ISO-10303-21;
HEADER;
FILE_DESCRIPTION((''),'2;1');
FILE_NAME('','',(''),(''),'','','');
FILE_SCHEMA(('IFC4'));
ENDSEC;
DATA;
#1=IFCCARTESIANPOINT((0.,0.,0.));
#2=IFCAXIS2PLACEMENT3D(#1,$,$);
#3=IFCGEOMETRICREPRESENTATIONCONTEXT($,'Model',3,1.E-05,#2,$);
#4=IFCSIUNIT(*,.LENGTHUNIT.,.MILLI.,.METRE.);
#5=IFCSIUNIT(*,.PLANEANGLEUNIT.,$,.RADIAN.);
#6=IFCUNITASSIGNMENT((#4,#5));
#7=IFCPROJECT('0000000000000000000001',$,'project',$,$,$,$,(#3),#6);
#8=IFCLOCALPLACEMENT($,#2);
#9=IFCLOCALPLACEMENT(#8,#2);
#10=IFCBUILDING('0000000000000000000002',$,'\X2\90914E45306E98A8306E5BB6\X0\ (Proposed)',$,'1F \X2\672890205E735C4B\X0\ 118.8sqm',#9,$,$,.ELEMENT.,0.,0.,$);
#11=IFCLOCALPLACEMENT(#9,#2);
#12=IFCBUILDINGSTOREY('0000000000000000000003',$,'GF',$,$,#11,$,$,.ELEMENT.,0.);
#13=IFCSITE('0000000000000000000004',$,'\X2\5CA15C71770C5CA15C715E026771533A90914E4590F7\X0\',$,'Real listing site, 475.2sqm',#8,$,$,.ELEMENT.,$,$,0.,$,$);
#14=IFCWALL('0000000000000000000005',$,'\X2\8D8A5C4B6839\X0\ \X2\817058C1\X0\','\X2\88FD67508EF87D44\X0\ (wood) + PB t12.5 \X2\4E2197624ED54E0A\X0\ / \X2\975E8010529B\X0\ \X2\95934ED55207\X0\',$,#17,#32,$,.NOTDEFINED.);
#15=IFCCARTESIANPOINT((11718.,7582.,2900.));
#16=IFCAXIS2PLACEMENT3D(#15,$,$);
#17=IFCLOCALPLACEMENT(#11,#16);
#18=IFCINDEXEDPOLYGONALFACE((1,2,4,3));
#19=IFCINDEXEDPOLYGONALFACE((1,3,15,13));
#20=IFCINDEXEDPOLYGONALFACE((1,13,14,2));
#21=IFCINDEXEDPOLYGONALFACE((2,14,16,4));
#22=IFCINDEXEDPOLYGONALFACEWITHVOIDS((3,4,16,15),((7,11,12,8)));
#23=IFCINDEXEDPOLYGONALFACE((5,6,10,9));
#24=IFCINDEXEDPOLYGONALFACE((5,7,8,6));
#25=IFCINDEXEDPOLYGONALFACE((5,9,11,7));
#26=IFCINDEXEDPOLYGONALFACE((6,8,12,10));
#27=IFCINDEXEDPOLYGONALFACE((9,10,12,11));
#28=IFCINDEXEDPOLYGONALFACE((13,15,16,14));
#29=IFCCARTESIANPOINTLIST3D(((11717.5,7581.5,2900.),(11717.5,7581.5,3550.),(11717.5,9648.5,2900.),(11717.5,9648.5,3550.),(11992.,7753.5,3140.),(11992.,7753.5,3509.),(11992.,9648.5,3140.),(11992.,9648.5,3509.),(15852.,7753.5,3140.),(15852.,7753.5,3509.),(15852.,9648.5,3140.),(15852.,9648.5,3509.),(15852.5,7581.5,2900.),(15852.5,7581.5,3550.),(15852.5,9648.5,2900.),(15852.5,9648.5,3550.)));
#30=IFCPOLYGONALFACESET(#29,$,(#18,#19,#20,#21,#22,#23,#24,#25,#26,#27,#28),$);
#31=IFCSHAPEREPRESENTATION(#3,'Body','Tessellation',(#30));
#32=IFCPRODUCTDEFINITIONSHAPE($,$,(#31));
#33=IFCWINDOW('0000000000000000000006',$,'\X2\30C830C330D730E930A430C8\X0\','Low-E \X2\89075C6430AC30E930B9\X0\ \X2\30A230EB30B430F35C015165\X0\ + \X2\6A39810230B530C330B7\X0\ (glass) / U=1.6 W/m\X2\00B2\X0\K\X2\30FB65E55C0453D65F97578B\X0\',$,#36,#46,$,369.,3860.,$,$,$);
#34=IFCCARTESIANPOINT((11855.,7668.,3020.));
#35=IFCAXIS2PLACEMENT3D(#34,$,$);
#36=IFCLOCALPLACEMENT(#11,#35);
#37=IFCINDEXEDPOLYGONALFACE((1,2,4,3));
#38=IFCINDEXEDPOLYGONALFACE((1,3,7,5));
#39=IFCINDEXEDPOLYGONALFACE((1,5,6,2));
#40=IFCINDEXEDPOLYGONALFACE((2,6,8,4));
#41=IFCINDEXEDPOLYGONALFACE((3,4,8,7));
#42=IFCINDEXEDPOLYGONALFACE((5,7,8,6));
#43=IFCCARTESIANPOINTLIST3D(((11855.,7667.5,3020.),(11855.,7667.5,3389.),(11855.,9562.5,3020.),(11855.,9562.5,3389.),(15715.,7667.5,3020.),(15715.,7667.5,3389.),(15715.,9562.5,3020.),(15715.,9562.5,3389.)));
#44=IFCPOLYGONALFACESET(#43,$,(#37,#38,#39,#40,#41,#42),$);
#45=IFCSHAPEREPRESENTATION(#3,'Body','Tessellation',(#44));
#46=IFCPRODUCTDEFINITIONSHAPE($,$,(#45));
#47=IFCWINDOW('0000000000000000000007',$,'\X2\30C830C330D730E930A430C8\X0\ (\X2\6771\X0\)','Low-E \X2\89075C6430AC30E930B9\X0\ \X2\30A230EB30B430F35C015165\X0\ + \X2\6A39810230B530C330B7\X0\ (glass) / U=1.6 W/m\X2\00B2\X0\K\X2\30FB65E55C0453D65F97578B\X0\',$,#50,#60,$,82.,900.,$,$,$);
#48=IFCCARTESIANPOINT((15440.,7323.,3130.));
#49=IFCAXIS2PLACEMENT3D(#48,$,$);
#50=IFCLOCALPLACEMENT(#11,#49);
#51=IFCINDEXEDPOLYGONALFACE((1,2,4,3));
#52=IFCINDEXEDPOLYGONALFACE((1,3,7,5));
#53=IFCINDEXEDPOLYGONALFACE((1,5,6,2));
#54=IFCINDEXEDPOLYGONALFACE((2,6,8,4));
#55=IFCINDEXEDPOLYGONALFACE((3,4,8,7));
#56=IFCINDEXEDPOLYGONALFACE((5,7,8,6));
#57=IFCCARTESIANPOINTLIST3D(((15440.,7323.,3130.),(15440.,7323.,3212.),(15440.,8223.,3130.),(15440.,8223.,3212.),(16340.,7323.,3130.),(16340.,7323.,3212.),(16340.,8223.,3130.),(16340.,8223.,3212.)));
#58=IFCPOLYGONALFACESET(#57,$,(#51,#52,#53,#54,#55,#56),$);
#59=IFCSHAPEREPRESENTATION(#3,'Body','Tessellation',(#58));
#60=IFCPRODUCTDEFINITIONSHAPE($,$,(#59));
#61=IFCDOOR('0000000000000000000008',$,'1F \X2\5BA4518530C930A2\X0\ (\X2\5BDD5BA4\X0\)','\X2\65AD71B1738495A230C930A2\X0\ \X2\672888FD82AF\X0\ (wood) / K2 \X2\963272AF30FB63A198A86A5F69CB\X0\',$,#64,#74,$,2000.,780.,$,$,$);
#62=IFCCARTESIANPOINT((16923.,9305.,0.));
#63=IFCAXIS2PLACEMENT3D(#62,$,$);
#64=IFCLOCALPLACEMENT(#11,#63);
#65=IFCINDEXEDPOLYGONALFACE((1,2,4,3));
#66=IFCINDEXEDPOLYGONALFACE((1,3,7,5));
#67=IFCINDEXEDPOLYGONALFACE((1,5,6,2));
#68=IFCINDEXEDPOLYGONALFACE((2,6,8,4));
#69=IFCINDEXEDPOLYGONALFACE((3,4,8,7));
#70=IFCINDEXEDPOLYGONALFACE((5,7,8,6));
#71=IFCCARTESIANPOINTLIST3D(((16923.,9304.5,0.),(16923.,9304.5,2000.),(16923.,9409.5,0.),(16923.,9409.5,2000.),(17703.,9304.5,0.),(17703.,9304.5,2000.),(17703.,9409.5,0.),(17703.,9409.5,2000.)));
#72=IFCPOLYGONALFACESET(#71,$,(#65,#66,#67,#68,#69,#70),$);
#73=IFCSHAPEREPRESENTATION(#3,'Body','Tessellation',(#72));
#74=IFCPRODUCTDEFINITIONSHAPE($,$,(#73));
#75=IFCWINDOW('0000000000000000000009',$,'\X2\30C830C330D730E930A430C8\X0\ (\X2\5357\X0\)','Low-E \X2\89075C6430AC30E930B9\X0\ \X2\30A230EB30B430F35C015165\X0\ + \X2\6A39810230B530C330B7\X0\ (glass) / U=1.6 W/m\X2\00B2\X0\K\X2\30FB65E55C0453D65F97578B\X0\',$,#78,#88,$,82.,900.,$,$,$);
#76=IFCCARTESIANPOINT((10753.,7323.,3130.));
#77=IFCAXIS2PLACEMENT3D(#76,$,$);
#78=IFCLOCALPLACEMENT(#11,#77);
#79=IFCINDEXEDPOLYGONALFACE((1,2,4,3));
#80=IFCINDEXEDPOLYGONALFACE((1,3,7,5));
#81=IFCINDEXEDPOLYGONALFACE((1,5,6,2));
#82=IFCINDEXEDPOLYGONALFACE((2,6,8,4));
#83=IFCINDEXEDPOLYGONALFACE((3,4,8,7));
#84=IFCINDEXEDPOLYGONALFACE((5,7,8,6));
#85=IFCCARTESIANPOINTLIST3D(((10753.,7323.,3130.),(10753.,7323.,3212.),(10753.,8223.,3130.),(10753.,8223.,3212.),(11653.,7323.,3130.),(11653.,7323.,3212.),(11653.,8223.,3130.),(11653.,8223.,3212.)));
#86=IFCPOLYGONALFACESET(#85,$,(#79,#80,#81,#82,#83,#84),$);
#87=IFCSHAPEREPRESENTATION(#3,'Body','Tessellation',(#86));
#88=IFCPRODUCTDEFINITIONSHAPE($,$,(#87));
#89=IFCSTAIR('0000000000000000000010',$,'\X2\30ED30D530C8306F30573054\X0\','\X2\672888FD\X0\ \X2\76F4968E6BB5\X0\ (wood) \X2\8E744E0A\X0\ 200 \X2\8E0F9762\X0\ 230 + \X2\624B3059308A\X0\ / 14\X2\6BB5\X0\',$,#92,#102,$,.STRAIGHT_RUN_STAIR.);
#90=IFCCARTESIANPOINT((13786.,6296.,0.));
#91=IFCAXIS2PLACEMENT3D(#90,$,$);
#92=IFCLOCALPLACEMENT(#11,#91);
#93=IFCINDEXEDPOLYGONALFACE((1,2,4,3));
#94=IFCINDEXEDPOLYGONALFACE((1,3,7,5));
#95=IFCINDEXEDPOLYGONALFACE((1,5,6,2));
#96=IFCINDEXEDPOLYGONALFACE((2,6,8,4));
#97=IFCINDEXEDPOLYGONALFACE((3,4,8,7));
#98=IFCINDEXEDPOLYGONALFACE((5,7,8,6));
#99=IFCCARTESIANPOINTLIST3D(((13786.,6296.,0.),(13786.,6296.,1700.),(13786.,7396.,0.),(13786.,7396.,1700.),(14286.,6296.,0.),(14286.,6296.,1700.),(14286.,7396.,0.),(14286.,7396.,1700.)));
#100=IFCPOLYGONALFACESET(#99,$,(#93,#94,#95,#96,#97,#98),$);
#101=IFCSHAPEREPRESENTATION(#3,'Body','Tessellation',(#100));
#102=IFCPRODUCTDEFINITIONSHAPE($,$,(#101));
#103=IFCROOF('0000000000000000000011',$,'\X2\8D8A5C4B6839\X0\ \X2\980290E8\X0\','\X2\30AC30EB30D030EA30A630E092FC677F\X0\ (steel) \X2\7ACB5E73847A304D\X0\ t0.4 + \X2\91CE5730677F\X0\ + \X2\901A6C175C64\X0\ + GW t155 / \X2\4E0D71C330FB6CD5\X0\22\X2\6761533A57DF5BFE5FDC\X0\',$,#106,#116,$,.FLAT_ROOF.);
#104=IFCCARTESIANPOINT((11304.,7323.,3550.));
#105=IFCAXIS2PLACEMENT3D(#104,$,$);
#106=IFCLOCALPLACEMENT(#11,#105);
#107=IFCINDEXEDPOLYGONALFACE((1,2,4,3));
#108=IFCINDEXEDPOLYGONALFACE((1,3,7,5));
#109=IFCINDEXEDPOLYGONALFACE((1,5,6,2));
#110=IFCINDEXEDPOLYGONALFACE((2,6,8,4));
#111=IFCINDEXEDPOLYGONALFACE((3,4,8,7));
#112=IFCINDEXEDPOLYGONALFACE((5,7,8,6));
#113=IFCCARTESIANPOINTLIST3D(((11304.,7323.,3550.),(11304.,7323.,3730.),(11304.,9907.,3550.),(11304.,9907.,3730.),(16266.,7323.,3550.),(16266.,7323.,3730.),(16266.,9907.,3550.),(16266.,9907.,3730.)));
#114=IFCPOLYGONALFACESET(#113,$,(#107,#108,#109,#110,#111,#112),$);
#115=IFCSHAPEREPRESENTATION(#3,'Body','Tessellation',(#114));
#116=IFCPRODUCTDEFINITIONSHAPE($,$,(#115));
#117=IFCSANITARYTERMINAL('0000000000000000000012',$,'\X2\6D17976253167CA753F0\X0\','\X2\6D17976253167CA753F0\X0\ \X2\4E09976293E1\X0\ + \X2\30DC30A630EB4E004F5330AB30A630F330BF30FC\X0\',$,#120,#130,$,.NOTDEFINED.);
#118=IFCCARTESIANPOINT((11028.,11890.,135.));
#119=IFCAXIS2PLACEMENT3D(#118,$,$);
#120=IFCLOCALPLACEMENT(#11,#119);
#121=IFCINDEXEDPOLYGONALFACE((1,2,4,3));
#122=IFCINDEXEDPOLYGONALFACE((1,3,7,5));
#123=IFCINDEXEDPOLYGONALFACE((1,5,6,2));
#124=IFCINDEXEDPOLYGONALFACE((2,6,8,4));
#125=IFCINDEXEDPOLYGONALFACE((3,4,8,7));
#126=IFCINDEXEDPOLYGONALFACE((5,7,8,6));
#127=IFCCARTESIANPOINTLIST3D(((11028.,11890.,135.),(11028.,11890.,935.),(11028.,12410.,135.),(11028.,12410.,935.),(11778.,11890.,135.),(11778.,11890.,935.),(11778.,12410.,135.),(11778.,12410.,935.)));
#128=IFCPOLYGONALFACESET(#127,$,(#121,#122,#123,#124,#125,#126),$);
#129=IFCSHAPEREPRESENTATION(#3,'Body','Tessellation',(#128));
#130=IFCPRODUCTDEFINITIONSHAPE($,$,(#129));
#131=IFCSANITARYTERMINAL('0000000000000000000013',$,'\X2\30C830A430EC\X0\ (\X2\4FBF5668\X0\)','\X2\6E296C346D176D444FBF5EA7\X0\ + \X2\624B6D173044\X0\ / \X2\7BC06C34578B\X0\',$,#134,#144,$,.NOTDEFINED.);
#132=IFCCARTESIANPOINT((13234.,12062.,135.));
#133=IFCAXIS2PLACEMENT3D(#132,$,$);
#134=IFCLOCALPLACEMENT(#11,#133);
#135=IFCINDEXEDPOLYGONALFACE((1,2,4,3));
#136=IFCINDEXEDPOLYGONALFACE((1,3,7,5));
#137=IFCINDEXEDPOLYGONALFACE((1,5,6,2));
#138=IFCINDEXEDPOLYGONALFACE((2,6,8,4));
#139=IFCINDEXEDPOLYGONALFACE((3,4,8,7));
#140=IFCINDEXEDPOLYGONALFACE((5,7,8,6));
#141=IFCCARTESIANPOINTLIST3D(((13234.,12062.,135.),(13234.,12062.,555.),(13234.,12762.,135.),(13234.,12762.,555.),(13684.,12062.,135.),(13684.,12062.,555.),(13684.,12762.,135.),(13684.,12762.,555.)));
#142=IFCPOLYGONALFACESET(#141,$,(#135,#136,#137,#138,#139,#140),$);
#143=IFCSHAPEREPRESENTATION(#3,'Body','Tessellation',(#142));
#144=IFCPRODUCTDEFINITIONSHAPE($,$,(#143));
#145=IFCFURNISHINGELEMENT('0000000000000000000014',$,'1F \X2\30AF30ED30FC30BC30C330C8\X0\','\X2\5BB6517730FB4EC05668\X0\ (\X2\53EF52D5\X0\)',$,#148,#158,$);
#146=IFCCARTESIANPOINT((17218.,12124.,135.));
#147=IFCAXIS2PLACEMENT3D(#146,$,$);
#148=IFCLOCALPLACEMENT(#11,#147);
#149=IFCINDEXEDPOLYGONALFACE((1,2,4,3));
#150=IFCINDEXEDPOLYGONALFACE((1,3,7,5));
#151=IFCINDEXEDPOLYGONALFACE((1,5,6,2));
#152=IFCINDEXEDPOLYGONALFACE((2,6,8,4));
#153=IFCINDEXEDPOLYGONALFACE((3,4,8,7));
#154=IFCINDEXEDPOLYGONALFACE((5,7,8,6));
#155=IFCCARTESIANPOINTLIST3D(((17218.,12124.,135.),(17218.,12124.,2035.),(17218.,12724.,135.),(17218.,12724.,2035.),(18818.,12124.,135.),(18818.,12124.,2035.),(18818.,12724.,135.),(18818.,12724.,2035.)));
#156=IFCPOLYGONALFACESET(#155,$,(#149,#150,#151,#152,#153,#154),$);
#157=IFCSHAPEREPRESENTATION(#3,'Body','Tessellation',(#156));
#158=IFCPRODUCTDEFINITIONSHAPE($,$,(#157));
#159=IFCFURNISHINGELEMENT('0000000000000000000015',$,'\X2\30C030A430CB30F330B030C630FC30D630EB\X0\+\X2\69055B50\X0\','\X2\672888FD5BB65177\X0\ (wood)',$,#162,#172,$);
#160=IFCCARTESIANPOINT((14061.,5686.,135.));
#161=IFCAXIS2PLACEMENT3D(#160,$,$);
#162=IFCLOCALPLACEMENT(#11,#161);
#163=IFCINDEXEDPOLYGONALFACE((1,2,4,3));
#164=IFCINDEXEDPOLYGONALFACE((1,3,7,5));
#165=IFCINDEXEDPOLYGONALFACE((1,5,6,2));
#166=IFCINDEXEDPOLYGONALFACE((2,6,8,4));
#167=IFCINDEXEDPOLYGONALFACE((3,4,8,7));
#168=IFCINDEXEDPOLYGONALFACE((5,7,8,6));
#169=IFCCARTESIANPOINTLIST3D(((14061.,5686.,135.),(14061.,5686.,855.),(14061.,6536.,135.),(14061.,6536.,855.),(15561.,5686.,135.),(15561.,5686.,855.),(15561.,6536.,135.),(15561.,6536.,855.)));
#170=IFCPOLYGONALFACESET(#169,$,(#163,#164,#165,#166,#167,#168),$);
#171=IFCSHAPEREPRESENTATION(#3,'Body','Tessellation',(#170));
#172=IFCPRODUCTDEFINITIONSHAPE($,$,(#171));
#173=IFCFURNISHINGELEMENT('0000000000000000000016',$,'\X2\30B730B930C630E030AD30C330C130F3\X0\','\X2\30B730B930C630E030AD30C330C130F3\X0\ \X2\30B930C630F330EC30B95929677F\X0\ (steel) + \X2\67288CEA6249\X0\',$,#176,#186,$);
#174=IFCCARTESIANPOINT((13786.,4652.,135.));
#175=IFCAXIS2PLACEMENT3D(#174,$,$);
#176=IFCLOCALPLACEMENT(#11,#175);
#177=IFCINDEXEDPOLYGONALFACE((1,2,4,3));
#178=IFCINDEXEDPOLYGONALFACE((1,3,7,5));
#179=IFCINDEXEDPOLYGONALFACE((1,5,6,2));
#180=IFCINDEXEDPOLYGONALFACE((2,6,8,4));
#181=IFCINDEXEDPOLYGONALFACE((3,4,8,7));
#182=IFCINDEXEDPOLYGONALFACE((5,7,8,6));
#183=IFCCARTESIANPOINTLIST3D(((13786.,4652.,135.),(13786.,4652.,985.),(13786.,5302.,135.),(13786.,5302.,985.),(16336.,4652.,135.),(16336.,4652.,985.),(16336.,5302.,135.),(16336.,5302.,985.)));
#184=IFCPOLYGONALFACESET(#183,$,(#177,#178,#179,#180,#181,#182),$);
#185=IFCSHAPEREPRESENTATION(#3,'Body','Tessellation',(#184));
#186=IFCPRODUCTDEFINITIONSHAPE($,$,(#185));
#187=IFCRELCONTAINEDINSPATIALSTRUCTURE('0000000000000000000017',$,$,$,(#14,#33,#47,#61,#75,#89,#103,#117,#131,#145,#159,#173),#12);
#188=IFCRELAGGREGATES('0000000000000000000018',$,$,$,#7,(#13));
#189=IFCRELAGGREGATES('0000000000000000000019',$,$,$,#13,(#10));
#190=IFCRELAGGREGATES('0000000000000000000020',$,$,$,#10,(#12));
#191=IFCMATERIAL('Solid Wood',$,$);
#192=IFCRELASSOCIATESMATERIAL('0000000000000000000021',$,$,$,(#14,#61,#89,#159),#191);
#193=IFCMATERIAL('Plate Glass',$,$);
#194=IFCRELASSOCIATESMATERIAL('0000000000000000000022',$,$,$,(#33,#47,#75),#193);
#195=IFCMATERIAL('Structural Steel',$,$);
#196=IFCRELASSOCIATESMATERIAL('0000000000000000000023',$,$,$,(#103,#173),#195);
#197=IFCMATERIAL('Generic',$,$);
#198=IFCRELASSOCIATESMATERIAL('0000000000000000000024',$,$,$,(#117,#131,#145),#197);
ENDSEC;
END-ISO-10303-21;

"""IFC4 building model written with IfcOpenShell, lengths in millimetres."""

from ifc_helpers import new_model, si_unit, frame, frame_2d, origin, place, context, project, spatial, rectangle, extrude, material, element, fill, save


model = new_model("IFC4")

# Units and contexts
model_context = context("Model", 3, precision=1e-05, world=origin())
ifc_project = project(units=[si_unit("LENGTHUNIT", "METRE", prefix="MILLI"), si_unit("PLANEANGLEUNIT", "RADIAN")], contexts=[model_context])

# Site, building, storey
site_placement = place(None, origin())
site = spatial("IfcSite", under=ifc_project, at=site_placement, Name="岡山県岡山市東区邑久郷", ObjectType="Real listing site, 475.2sqm", CompositionType="ELEMENT", RefElevation=0.0)
building_placement = place(site_placement, origin())
building = spatial("IfcBuilding", under=site, at=building_placement, Name="邑久の風の家 (Proposed)", ObjectType="1F 木造平屋 118.8sqm", CompositionType="ELEMENT", ElevationOfRefHeight=0.0, ElevationOfTerrain=0.0)
storey_placement = place(building_placement, origin())
storey = spatial("IfcBuildingStorey", under=building, at=storey_placement, Name="GF", CompositionType="ELEMENT", Elevation=0.0)

# Shared definitions
ifc_material_1 = material(Name="Solid Wood")
ifc_material_2 = material(Name="Plate Glass")

# Wall, openings, windows
wall_1_placement = place(storey_placement, frame((11718.0, 7582.0, 2900.0)))
wall_1 = element("IfcWall", 1, at=wall_1_placement, inside=storey, material=ifc_material_1, Name="越屋根 腰壁", Description="製材軸組 (wood) + PB t12.5 両面仕上 / 非耐力 間仕切", PredefinedType="NOTDEFINED", context=model_context, shape_type="SweptSolid", body=[
    extrude(rectangle(XDim=4135.0, YDim=2067.0, at=frame_2d((2067.0, 1033.0))), frame((11718.0, 7582.0, 2900.0)), (0.0, 0.0, 1.0), 650.0),
])
opening_1_placement = place(storey_placement, frame((11855.0, 7668.0, 3020.0)))
opening_1 = element("IfcOpeningElement", 2, at=opening_1_placement, cuts=wall_1, PredefinedType="NOTDEFINED", context=model_context, shape_type="SweptSolid", body=[
    extrude(rectangle(XDim=3860.0, YDim=1895.0, at=frame_2d((1930.0, 947.0))), frame((11855.0, 7668.0, 3020.0)), (0.0, 0.0, 1.0), 369.0),
])
opening_2_placement = place(storey_placement, frame((15440.0, 7323.0, 3130.0)))
opening_2 = element("IfcOpeningElement", 3, at=opening_2_placement, cuts=wall_1, PredefinedType="NOTDEFINED", context=model_context, shape_type="SweptSolid", body=[
    extrude(rectangle(XDim=900.0, YDim=900.0, at=frame_2d((450.0, 450.0))), frame((15440.0, 7323.0, 3130.0)), (0.0, 0.0, 1.0), 82.0),
])
window_1_placement = place(storey_placement, frame((11855.0, 7668.0, 3020.0)))
window_1 = element("IfcWindow", 4, at=window_1_placement, inside=storey, material=ifc_material_2, Name="トップライト", Description="Low-E 複層ガラス アルゴン封入 + 樹脂サッシ (glass) / U=1.6 W/m²K・日射取得型", OverallHeight=369.0, OverallWidth=3860.0, context=model_context, shape_type="SweptSolid", body=[
    extrude(rectangle(XDim=3860.0, YDim=1895.0, at=frame_2d((1930.0, 947.0))), frame((11855.0, 7668.0, 3020.0)), (0.0, 0.0, 1.0), 369.0),
])
fill(opening_1, window_1)
window_2_placement = place(storey_placement, frame((15440.0, 7323.0, 3130.0)))
window_2 = element("IfcWindow", 5, at=window_2_placement, inside=storey, material=ifc_material_2, Name="トップライト (東)", Description="Low-E 複層ガラス アルゴン封入 + 樹脂サッシ (glass) / U=1.6 W/m²K・日射取得型", OverallHeight=82.0, OverallWidth=900.0, context=model_context, shape_type="SweptSolid", body=[
    extrude(rectangle(XDim=900.0, YDim=900.0, at=frame_2d((450.0, 450.0))), frame((15440.0, 7323.0, 3130.0)), (0.0, 0.0, 1.0), 82.0),
])
fill(opening_2, window_2)

# Door
door_placement = place(storey_placement, frame((16923.0, 9305.0, 0.0)))
element("IfcDoor", 6, at=door_placement, inside=storey, material=ifc_material_1, Name="1F 室内ドア (寝室)", Description="断熱玄関ドア 木製芯 (wood) / K2 防犯・採風機構", OverallHeight=2000.0, OverallWidth=780.0, context=model_context, shape_type="SweptSolid", body=[
    extrude(rectangle(XDim=780.0, YDim=105.0, at=frame_2d((390.0, 52.0))), frame((16923.0, 9305.0, 0.0)), (0.0, 0.0, 1.0), 2000.0),
])

# Window
window_3_placement = place(storey_placement, frame((10753.0, 7323.0, 3130.0)))
element("IfcWindow", 7, at=window_3_placement, inside=storey, material=ifc_material_2, Name="トップライト (南)", Description="Low-E 複層ガラス アルゴン封入 + 樹脂サッシ (glass) / U=1.6 W/m²K・日射取得型", OverallHeight=82.0, OverallWidth=900.0, context=model_context, shape_type="SweptSolid", body=[
    extrude(rectangle(XDim=900.0, YDim=900.0, at=frame_2d((450.0, 450.0))), frame((10753.0, 7323.0, 3130.0)), (0.0, 0.0, 1.0), 82.0),
])

# Stair
stair_placement = place(storey_placement, frame((13786.0, 6296.0, 0.0)))
element("IfcStair", 8, at=stair_placement, inside=storey, material=ifc_material_1, Name="ロフトはしご", Description="木製 直階段 (wood) 蹴上 200 踏面 230 + 手すり / 14段", PredefinedType="STRAIGHT_RUN_STAIR", context=model_context, shape_type="SweptSolid", body=[
    extrude(rectangle(XDim=500.0, YDim=1100.0, at=frame_2d((250.0, 550.0))), frame((13786.0, 6296.0, 0.0)), (0.0, 0.0, 1.0), 1700.0),
])

# Roof
ifc_material_3 = material(Name="Structural Steel")
roof_placement = place(storey_placement, frame((11304.0, 7323.0, 3550.0)))
element("IfcRoof", 9, at=roof_placement, inside=storey, material=ifc_material_3, Name="越屋根 頂部", Description="ガルバリウム鋼板 (steel) 立平葺き t0.4 + 野地板 + 通気層 + GW t155 / 不燃・法22条区域対応", PredefinedType="FLAT_ROOF", context=model_context, shape_type="SweptSolid", body=[
    extrude(rectangle(XDim=4962.0, YDim=2584.0, at=frame_2d((2481.0, 1292.0))), frame((11304.0, 7323.0, 3550.0)), (0.0, 0.0, 1.0), 180.0),
])

# Sanitary terminals
ifc_material_4 = material(Name="Generic")
sanitary_terminal_1_placement = place(storey_placement, frame((11028.0, 11890.0, 135.0)))
element("IfcSanitaryTerminal", 10, at=sanitary_terminal_1_placement, inside=storey, material=ifc_material_4, Name="洗面化粧台", Description="洗面化粧台 三面鏡 + ボウル一体カウンター", PredefinedType="NOTDEFINED", context=model_context, shape_type="SweptSolid", body=[
    extrude(rectangle(XDim=750.0, YDim=520.0, at=frame_2d((375.0, 260.0))), frame((11028.0, 11890.0, 135.0)), (0.0, 0.0, 1.0), 800.0),
])
sanitary_terminal_2_placement = place(storey_placement, frame((13234.0, 12062.0, 135.0)))
element("IfcSanitaryTerminal", 11, at=sanitary_terminal_2_placement, inside=storey, material=ifc_material_4, Name="トイレ (便器)", Description="温水洗浄便座 + 手洗い / 節水型", PredefinedType="NOTDEFINED", context=model_context, shape_type="SweptSolid", body=[
    extrude(rectangle(XDim=450.0, YDim=700.0, at=frame_2d((225.0, 350.0))), frame((13234.0, 12062.0, 135.0)), (0.0, 0.0, 1.0), 420.0),
])

# Furnishing elements
furnishing_1_placement = place(storey_placement, frame((17218.0, 12124.0, 135.0)))
element("IfcFurnishingElement", 12, at=furnishing_1_placement, inside=storey, material=ifc_material_4, Name="1F クローゼット", Description="家具・什器 (可動)", context=model_context, shape_type="SweptSolid", body=[
    extrude(rectangle(XDim=1600.0, YDim=600.0, at=frame_2d((800.0, 300.0))), frame((17218.0, 12124.0, 135.0)), (0.0, 0.0, 1.0), 1900.0),
])
furnishing_2_placement = place(storey_placement, frame((14061.0, 5686.0, 135.0)))
element("IfcFurnishingElement", 13, at=furnishing_2_placement, inside=storey, material=ifc_material_1, Name="ダイニングテーブル+椅子", Description="木製家具 (wood)", context=model_context, shape_type="SweptSolid", body=[
    extrude(rectangle(XDim=1500.0, YDim=850.0, at=frame_2d((750.0, 425.0))), frame((14061.0, 5686.0, 135.0)), (0.0, 0.0, 1.0), 720.0),
])
furnishing_3_placement = place(storey_placement, frame((13786.0, 4652.0, 135.0)))
element("IfcFurnishingElement", 14, at=furnishing_3_placement, inside=storey, material=ifc_material_3, Name="システムキッチン", Description="システムキッチン ステンレス天板 (steel) + 木質扉", context=model_context, shape_type="SweptSolid", body=[
    extrude(rectangle(XDim=2550.0, YDim=650.0, at=frame_2d((1275.0, 325.0))), frame((13786.0, 4652.0, 135.0)), (0.0, 0.0, 1.0), 850.0),
])

save(model, "model.ifc")
